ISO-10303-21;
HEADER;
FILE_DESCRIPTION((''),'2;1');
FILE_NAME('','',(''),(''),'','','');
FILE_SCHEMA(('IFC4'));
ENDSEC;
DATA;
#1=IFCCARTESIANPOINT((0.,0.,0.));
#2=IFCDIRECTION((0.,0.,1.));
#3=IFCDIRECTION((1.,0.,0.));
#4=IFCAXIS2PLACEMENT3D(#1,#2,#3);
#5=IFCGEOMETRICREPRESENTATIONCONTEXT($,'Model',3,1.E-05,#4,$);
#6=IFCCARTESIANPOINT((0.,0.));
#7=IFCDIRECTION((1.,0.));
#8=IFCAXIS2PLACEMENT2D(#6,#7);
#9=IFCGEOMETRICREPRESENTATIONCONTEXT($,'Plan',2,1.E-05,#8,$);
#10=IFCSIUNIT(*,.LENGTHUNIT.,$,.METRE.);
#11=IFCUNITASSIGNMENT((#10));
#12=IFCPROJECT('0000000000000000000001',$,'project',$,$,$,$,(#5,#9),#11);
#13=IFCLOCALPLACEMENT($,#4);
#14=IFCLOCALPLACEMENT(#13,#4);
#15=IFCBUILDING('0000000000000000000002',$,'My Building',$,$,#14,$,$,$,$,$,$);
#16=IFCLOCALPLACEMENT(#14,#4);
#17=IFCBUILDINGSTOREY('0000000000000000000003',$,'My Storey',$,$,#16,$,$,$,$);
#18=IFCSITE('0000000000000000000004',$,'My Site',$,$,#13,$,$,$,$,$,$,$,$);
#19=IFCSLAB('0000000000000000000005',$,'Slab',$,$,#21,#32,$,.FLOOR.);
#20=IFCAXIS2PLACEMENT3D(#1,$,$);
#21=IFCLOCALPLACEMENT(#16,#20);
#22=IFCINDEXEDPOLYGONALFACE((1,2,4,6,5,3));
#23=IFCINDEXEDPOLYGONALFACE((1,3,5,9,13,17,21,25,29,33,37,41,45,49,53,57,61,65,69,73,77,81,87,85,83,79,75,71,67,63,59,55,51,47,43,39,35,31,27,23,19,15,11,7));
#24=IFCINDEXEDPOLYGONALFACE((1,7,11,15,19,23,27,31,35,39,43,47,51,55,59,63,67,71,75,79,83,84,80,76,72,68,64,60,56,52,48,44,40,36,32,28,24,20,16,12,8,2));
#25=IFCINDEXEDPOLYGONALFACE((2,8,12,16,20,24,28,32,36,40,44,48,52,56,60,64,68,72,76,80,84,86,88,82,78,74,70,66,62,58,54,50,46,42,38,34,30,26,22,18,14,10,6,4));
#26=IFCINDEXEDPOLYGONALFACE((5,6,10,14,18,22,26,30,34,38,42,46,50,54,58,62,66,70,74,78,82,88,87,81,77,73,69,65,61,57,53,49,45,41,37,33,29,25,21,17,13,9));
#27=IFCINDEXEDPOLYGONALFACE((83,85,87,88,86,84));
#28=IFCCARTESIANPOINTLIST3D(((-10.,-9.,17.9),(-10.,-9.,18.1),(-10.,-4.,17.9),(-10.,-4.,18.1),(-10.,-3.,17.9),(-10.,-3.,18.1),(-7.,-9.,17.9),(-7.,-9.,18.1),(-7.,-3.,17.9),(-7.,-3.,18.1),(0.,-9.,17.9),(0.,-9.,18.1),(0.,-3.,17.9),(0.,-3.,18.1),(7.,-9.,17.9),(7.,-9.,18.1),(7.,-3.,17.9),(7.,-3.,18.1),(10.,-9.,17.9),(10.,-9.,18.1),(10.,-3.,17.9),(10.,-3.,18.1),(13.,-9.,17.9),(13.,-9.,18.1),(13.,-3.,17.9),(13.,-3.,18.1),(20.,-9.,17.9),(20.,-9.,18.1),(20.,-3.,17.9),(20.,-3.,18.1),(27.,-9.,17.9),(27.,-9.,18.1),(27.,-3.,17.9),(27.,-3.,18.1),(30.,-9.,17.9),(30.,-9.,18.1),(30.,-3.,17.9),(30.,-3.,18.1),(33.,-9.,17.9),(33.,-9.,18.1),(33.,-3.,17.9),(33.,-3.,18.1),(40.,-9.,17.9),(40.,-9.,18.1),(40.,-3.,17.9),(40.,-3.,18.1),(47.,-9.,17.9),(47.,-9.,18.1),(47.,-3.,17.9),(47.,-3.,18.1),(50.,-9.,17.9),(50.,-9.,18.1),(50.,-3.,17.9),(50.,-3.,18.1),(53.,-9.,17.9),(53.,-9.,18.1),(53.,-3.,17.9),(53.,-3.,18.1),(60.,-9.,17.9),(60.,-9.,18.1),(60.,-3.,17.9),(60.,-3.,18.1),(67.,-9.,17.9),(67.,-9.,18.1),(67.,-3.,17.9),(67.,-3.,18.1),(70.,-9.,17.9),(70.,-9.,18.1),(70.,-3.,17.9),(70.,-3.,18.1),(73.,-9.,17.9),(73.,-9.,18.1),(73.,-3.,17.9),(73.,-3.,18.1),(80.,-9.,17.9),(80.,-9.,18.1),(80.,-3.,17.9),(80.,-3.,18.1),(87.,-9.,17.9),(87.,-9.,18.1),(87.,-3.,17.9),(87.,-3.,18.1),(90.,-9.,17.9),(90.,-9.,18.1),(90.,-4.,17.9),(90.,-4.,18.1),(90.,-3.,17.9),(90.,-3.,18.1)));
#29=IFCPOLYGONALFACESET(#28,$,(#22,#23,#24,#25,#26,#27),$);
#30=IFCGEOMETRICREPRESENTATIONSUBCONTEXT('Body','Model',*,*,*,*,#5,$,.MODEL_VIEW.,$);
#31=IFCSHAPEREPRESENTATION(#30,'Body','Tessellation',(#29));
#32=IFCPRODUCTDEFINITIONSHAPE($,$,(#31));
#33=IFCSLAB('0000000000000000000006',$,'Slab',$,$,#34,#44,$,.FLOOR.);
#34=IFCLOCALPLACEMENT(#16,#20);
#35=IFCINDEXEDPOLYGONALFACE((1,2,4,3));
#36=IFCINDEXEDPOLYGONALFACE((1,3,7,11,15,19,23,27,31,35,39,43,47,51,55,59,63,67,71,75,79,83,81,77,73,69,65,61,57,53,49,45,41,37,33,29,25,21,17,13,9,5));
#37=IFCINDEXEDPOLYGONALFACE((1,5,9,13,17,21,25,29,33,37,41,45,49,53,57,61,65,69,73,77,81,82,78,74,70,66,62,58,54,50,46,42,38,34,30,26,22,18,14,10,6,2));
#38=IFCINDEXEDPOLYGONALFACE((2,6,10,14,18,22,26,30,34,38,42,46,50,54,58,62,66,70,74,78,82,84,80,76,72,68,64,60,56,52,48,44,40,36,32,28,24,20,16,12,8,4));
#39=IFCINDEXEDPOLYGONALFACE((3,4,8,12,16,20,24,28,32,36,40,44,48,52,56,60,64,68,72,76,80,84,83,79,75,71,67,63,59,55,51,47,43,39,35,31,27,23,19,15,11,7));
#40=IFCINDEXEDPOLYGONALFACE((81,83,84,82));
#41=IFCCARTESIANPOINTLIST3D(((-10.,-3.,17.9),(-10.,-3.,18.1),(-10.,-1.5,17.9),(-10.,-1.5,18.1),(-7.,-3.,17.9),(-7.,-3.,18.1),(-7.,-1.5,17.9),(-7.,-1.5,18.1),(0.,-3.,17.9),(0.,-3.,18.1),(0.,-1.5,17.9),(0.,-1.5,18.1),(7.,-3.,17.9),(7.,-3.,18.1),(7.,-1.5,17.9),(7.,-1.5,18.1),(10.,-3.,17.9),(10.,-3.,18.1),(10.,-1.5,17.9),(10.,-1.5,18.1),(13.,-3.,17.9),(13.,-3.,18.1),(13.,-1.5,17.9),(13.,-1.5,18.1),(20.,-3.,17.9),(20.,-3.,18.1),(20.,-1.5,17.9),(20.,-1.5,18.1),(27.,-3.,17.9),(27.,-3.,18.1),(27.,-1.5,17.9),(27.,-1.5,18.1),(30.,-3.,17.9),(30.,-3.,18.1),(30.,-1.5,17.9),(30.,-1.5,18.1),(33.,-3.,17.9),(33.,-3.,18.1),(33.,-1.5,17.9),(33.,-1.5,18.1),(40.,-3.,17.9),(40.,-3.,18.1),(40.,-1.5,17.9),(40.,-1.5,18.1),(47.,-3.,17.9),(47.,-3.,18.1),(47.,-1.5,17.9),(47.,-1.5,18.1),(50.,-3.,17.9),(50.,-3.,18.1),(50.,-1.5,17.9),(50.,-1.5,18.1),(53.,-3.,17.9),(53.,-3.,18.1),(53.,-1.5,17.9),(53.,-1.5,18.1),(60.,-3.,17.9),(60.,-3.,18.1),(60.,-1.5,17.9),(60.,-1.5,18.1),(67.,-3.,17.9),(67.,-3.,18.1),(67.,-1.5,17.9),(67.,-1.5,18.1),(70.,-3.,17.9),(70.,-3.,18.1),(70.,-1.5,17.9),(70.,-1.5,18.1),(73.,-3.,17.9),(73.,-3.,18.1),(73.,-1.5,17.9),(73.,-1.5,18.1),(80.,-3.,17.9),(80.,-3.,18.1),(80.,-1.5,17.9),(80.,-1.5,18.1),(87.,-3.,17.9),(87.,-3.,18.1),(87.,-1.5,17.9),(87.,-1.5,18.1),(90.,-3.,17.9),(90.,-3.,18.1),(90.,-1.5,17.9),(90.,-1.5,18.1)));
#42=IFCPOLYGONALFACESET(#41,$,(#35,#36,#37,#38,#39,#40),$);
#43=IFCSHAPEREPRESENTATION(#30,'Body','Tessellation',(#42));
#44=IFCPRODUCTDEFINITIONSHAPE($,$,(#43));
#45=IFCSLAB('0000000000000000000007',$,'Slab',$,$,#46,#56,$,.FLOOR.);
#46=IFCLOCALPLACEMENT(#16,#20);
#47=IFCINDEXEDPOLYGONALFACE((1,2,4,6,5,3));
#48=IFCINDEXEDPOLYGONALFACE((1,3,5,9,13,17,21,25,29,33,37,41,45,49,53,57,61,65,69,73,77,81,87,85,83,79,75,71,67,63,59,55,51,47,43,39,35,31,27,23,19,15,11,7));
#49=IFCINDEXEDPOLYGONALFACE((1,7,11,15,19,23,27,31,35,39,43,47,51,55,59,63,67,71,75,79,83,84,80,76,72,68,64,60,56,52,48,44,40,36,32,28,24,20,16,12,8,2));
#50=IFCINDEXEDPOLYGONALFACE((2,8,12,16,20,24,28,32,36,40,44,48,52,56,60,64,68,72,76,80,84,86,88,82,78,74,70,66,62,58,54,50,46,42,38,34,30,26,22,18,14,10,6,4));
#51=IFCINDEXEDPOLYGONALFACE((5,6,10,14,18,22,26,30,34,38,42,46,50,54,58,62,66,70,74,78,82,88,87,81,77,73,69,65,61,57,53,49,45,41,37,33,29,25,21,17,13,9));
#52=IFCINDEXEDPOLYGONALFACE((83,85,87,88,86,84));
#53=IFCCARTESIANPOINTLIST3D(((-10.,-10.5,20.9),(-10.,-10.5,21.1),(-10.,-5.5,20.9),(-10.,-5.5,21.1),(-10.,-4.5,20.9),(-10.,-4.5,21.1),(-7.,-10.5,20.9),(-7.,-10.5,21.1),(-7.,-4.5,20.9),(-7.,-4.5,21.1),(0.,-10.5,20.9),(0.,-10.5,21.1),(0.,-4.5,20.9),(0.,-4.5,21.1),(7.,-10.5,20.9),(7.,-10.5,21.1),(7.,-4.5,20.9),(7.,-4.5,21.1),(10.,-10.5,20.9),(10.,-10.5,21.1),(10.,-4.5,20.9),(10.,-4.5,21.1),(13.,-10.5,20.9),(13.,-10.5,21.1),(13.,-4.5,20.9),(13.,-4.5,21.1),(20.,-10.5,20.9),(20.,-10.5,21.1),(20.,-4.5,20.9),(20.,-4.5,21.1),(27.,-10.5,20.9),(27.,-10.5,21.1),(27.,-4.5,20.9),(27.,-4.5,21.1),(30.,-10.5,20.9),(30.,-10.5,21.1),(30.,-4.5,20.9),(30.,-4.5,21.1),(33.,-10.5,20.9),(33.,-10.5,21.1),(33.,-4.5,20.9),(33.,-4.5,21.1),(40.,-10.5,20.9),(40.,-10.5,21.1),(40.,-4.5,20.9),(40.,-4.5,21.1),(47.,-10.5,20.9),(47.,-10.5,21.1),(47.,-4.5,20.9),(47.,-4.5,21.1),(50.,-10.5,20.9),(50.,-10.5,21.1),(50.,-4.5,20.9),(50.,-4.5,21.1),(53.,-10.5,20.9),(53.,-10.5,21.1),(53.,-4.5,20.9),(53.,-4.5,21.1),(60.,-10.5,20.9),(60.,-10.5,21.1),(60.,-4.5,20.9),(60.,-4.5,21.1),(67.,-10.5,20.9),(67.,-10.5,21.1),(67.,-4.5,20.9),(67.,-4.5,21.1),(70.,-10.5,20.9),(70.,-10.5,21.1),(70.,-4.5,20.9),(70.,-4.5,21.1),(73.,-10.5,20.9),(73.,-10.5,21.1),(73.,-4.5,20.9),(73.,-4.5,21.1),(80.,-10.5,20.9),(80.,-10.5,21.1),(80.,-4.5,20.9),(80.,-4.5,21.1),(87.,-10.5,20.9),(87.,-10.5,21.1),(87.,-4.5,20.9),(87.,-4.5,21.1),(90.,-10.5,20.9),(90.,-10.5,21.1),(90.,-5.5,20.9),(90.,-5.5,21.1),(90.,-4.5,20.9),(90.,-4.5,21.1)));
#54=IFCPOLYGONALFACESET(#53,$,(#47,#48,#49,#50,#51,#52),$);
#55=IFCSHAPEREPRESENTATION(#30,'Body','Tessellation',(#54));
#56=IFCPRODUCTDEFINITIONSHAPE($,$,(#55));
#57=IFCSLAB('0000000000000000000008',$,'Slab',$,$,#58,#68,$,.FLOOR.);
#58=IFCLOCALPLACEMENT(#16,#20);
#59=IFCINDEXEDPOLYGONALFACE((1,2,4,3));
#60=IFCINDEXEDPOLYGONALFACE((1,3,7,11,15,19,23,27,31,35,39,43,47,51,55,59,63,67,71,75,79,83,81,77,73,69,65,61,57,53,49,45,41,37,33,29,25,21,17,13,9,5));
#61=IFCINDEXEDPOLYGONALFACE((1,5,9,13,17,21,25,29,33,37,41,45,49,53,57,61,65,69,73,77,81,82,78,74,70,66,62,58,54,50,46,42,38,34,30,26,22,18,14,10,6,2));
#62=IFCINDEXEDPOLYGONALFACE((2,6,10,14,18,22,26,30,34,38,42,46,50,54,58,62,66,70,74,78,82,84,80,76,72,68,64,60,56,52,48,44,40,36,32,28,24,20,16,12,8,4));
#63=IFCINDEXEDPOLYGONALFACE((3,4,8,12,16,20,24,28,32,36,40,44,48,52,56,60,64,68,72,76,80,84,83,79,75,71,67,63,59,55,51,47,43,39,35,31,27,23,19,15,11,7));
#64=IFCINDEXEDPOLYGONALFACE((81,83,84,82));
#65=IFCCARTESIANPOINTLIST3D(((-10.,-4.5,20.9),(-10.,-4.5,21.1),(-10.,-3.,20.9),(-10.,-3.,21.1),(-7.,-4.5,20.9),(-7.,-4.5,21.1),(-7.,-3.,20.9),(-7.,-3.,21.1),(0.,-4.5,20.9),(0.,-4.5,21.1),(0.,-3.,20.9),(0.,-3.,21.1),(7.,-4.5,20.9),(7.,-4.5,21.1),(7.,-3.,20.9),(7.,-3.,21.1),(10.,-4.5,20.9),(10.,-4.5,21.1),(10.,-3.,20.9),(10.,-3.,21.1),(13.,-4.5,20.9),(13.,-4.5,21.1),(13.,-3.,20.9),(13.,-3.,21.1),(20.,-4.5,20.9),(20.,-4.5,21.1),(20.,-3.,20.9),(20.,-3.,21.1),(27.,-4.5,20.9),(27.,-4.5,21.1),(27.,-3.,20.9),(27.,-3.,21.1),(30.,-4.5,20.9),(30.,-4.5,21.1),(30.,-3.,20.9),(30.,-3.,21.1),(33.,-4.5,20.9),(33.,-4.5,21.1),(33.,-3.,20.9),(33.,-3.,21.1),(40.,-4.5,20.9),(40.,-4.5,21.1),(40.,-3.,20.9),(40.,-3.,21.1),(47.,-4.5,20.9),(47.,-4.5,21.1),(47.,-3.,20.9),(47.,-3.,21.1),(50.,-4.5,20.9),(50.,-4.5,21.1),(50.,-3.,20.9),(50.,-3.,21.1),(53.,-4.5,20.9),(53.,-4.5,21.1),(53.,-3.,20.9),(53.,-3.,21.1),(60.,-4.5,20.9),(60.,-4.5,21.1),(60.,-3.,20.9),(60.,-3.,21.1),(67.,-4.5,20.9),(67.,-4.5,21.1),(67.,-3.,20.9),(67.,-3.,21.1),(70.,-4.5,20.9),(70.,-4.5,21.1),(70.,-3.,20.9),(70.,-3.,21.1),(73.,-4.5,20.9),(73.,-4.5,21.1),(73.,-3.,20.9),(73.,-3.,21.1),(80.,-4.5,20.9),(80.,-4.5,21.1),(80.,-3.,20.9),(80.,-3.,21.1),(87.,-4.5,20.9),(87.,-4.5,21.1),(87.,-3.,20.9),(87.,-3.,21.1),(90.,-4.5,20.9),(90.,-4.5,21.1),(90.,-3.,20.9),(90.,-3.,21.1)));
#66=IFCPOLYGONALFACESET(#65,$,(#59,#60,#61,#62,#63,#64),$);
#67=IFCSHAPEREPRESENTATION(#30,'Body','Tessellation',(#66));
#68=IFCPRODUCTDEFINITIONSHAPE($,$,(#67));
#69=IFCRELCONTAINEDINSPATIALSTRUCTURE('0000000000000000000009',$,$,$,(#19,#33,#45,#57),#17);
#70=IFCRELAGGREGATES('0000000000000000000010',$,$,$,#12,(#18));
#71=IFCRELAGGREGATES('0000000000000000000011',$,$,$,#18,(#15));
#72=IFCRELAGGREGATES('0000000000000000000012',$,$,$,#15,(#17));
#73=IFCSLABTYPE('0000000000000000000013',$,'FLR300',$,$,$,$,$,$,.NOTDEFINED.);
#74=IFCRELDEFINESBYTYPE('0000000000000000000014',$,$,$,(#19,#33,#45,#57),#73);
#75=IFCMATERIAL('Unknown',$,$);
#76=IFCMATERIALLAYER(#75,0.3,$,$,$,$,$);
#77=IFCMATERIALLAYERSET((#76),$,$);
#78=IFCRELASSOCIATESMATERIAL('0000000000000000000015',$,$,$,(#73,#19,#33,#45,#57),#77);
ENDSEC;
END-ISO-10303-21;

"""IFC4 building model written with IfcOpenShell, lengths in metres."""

from ifc_helpers import new_model, si_unit, frame, origin, origin_with_axes, origin_2d_with_axis, place, context, subcontext, project, spatial, polyline, outline, extrude, material, layer, layer_set, layer_usage, type_object, element, save


model = new_model("IFC4")

# Units and contexts
model_context = context("Model", 3, precision=1e-05, world=origin_with_axes())
plan_context = context("Plan", 2, precision=1e-05, world=origin_2d_with_axis())
body_context = subcontext(model_context, "Body", "Model", "MODEL_VIEW")
ifc_project = project(units=[si_unit("LENGTHUNIT", "METRE")], contexts=[model_context, plan_context])

# Site, building, storey
site_placement = place(None, origin_with_axes())
site = spatial("IfcSite", under=ifc_project, at=site_placement, Name="My Site")
building_placement = place(site_placement, origin_with_axes())
building = spatial("IfcBuilding", under=site, at=building_placement, Name="My Building")
storey_placement = place(building_placement, origin_with_axes())
storey = spatial("IfcBuildingStorey", under=building, at=storey_placement, Name="My Storey")

# Slabs
ifc_material = material(Name="Unknown")
ifc_layer_1 = layer(ifc_material, 0.3)
ifc_layer_set_1 = layer_set([ifc_layer_1])
ifc_layer_usage_1 = layer_usage(ifc_layer_set_1, "AXIS3", "POSITIVE", 0.0)
slab_type = type_object("IfcSlabType", Name="FLR300", PredefinedType="NOTDEFINED", material=ifc_layer_set_1)
slab_1_placement = place(storey_placement, frame((40.0, -5.9091, 17.9), z_axis=(0.0, 0.0, 1.0), x_axis=(1.0, 0.0, 0.0)))
element("IfcSlab", 1, at=slab_1_placement, inside=storey, type_object=slab_type, material=ifc_layer_usage_1, Name="Slab", PredefinedType="FLOOR", context=body_context, shape_type="SweptSolid", body=[
    extrude(outline(polyline([(-47.0, 2.9091), (-50.0, 2.9091), (-50.0, 1.9091), (-50.0, -3.0909), (-47.0, -3.0909), (-40.0, -3.0909), (-33.0, -3.0909), (-30.0, -3.0909), (-27.0, -3.0909), (-20.0, -3.0909), (-13.0, -3.0909), (-10.0, -3.0909), (-7.0, -3.0909), (0.0, -3.0909), (7.0, -3.0909), (10.0, -3.0909), (13.0, -3.0909), (20.0, -3.0909), (27.0, -3.0909), (30.0, -3.0909), (33.0, -3.0909), (40.0, -3.0909), (47.0, -3.0909), (50.0, -3.0909), (50.0, 1.9091), (50.0, 2.9091), (47.0, 2.9091), (40.0, 2.9091), (33.0, 2.9091), (30.0, 2.9091), (27.0, 2.9091), (20.0, 2.9091), (13.0, 2.9091), (10.0, 2.9091), (7.0, 2.9091), (0.0, 2.9091), (-7.0, 2.9091), (-10.0, 2.9091), (-13.0, 2.9091), (-20.0, 2.9091), (-27.0, 2.9091), (-30.0, 2.9091), (-33.0, 2.9091), (-40.0, 2.9091), (-47.0, 2.9091)])), origin(), (0.0, 0.0, 1.0), 0.2),
])
ifc_layer_usage_2 = layer_usage(ifc_layer_set_1, "AXIS3", "POSITIVE", 0.0)
slab_2_placement = place(storey_placement, frame((40.0, -2.25, 17.9), z_axis=(0.0, 0.0, 1.0), x_axis=(1.0, 0.0, 0.0)))
element("IfcSlab", 2, at=slab_2_placement, inside=storey, type_object=slab_type, material=ifc_layer_usage_2, Name="Slab", PredefinedType="FLOOR", context=body_context, shape_type="SweptSolid", body=[
    extrude(outline(polyline([(-40.0, -0.75), (-33.0, -0.75), (-30.0, -0.75), (-27.0, -0.75), (-20.0, -0.75), (-13.0, -0.75), (-10.0, -0.75), (-7.0, -0.75), (0.0, -0.75), (7.0, -0.75), (10.0, -0.75), (13.0, -0.75), (20.0, -0.75), (27.0, -0.75), (30.0, -0.75), (33.0, -0.75), (40.0, -0.75), (47.0, -0.75), (50.0, -0.75), (50.0, 0.75), (47.0, 0.75), (40.0, 0.75), (33.0, 0.75), (30.0, 0.75), (27.0, 0.75), (20.0, 0.75), (13.0, 0.75), (10.0, 0.75), (7.0, 0.75), (0.0, 0.75), (-7.0, 0.75), (-10.0, 0.75), (-13.0, 0.75), (-20.0, 0.75), (-27.0, 0.75), (-30.0, 0.75), (-33.0, 0.75), (-40.0, 0.75), (-47.0, 0.75), (-50.0, 0.75), (-50.0, -0.75), (-47.0, -0.75), (-40.0, -0.75)])), origin(), (0.0, 0.0, 1.0), 0.2),
])
ifc_layer_usage_3 = layer_usage(ifc_layer_set_1, "AXIS3", "POSITIVE", 0.0)
slab_3_placement = place(storey_placement, frame((40.0, -7.4091, 20.9), z_axis=(0.0, 0.0, 1.0), x_axis=(1.0, 0.0, 0.0)))
element("IfcSlab", 3, at=slab_3_placement, inside=storey, type_object=slab_type, material=ifc_layer_usage_3, Name="Slab", PredefinedType="FLOOR", context=body_context, shape_type="SweptSolid", body=[
    extrude(outline(polyline([(-47.0, 2.9091), (-50.0, 2.9091), (-50.0, 1.9091), (-50.0, -3.0909), (-47.0, -3.0909), (-40.0, -3.0909), (-33.0, -3.0909), (-30.0, -3.0909), (-27.0, -3.0909), (-20.0, -3.0909), (-13.0, -3.0909), (-10.0, -3.0909), (-7.0, -3.0909), (0.0, -3.0909), (7.0, -3.0909), (10.0, -3.0909), (13.0, -3.0909), (20.0, -3.0909), (27.0, -3.0909), (30.0, -3.0909), (33.0, -3.0909), (40.0, -3.0909), (47.0, -3.0909), (50.0, -3.0909), (50.0, 1.9091), (50.0, 2.9091), (47.0, 2.9091), (40.0, 2.9091), (33.0, 2.9091), (30.0, 2.9091), (27.0, 2.9091), (20.0, 2.9091), (13.0, 2.9091), (10.0, 2.9091), (7.0, 2.9091), (0.0, 2.9091), (-7.0, 2.9091), (-10.0, 2.9091), (-13.0, 2.9091), (-20.0, 2.9091), (-27.0, 2.9091), (-30.0, 2.9091), (-33.0, 2.9091), (-40.0, 2.9091), (-47.0, 2.9091)])), origin(), (0.0, 0.0, 1.0), 0.2),
])
ifc_layer_usage_4 = layer_usage(ifc_layer_set_1, "AXIS3", "POSITIVE", 0.0)
slab_4_placement = place(storey_placement, frame((40.0, -3.75, 20.9), z_axis=(0.0, 0.0, 1.0), x_axis=(1.0, 0.0, 0.0)))
element("IfcSlab", 4, at=slab_4_placement, inside=storey, type_object=slab_type, material=ifc_layer_usage_4, Name="Slab", PredefinedType="FLOOR", context=body_context, shape_type="SweptSolid", body=[
    extrude(outline(polyline([(-40.0, -0.75), (-33.0, -0.75), (-30.0, -0.75), (-27.0, -0.75), (-20.0, -0.75), (-13.0, -0.75), (-10.0, -0.75), (-7.0, -0.75), (0.0, -0.75), (7.0, -0.75), (10.0, -0.75), (13.0, -0.75), (20.0, -0.75), (27.0, -0.75), (30.0, -0.75), (33.0, -0.75), (40.0, -0.75), (47.0, -0.75), (50.0, -0.75), (50.0, 0.75), (47.0, 0.75), (40.0, 0.75), (33.0, 0.75), (30.0, 0.75), (27.0, 0.75), (20.0, 0.75), (13.0, 0.75), (10.0, 0.75), (7.0, 0.75), (0.0, 0.75), (-7.0, 0.75), (-10.0, 0.75), (-13.0, 0.75), (-20.0, 0.75), (-27.0, 0.75), (-30.0, 0.75), (-33.0, 0.75), (-40.0, 0.75), (-47.0, 0.75), (-50.0, 0.75), (-50.0, -0.75), (-47.0, -0.75), (-40.0, -0.75)])), origin(), (0.0, 0.0, 1.0), 0.2),
])

save(model, "model.ifc")
